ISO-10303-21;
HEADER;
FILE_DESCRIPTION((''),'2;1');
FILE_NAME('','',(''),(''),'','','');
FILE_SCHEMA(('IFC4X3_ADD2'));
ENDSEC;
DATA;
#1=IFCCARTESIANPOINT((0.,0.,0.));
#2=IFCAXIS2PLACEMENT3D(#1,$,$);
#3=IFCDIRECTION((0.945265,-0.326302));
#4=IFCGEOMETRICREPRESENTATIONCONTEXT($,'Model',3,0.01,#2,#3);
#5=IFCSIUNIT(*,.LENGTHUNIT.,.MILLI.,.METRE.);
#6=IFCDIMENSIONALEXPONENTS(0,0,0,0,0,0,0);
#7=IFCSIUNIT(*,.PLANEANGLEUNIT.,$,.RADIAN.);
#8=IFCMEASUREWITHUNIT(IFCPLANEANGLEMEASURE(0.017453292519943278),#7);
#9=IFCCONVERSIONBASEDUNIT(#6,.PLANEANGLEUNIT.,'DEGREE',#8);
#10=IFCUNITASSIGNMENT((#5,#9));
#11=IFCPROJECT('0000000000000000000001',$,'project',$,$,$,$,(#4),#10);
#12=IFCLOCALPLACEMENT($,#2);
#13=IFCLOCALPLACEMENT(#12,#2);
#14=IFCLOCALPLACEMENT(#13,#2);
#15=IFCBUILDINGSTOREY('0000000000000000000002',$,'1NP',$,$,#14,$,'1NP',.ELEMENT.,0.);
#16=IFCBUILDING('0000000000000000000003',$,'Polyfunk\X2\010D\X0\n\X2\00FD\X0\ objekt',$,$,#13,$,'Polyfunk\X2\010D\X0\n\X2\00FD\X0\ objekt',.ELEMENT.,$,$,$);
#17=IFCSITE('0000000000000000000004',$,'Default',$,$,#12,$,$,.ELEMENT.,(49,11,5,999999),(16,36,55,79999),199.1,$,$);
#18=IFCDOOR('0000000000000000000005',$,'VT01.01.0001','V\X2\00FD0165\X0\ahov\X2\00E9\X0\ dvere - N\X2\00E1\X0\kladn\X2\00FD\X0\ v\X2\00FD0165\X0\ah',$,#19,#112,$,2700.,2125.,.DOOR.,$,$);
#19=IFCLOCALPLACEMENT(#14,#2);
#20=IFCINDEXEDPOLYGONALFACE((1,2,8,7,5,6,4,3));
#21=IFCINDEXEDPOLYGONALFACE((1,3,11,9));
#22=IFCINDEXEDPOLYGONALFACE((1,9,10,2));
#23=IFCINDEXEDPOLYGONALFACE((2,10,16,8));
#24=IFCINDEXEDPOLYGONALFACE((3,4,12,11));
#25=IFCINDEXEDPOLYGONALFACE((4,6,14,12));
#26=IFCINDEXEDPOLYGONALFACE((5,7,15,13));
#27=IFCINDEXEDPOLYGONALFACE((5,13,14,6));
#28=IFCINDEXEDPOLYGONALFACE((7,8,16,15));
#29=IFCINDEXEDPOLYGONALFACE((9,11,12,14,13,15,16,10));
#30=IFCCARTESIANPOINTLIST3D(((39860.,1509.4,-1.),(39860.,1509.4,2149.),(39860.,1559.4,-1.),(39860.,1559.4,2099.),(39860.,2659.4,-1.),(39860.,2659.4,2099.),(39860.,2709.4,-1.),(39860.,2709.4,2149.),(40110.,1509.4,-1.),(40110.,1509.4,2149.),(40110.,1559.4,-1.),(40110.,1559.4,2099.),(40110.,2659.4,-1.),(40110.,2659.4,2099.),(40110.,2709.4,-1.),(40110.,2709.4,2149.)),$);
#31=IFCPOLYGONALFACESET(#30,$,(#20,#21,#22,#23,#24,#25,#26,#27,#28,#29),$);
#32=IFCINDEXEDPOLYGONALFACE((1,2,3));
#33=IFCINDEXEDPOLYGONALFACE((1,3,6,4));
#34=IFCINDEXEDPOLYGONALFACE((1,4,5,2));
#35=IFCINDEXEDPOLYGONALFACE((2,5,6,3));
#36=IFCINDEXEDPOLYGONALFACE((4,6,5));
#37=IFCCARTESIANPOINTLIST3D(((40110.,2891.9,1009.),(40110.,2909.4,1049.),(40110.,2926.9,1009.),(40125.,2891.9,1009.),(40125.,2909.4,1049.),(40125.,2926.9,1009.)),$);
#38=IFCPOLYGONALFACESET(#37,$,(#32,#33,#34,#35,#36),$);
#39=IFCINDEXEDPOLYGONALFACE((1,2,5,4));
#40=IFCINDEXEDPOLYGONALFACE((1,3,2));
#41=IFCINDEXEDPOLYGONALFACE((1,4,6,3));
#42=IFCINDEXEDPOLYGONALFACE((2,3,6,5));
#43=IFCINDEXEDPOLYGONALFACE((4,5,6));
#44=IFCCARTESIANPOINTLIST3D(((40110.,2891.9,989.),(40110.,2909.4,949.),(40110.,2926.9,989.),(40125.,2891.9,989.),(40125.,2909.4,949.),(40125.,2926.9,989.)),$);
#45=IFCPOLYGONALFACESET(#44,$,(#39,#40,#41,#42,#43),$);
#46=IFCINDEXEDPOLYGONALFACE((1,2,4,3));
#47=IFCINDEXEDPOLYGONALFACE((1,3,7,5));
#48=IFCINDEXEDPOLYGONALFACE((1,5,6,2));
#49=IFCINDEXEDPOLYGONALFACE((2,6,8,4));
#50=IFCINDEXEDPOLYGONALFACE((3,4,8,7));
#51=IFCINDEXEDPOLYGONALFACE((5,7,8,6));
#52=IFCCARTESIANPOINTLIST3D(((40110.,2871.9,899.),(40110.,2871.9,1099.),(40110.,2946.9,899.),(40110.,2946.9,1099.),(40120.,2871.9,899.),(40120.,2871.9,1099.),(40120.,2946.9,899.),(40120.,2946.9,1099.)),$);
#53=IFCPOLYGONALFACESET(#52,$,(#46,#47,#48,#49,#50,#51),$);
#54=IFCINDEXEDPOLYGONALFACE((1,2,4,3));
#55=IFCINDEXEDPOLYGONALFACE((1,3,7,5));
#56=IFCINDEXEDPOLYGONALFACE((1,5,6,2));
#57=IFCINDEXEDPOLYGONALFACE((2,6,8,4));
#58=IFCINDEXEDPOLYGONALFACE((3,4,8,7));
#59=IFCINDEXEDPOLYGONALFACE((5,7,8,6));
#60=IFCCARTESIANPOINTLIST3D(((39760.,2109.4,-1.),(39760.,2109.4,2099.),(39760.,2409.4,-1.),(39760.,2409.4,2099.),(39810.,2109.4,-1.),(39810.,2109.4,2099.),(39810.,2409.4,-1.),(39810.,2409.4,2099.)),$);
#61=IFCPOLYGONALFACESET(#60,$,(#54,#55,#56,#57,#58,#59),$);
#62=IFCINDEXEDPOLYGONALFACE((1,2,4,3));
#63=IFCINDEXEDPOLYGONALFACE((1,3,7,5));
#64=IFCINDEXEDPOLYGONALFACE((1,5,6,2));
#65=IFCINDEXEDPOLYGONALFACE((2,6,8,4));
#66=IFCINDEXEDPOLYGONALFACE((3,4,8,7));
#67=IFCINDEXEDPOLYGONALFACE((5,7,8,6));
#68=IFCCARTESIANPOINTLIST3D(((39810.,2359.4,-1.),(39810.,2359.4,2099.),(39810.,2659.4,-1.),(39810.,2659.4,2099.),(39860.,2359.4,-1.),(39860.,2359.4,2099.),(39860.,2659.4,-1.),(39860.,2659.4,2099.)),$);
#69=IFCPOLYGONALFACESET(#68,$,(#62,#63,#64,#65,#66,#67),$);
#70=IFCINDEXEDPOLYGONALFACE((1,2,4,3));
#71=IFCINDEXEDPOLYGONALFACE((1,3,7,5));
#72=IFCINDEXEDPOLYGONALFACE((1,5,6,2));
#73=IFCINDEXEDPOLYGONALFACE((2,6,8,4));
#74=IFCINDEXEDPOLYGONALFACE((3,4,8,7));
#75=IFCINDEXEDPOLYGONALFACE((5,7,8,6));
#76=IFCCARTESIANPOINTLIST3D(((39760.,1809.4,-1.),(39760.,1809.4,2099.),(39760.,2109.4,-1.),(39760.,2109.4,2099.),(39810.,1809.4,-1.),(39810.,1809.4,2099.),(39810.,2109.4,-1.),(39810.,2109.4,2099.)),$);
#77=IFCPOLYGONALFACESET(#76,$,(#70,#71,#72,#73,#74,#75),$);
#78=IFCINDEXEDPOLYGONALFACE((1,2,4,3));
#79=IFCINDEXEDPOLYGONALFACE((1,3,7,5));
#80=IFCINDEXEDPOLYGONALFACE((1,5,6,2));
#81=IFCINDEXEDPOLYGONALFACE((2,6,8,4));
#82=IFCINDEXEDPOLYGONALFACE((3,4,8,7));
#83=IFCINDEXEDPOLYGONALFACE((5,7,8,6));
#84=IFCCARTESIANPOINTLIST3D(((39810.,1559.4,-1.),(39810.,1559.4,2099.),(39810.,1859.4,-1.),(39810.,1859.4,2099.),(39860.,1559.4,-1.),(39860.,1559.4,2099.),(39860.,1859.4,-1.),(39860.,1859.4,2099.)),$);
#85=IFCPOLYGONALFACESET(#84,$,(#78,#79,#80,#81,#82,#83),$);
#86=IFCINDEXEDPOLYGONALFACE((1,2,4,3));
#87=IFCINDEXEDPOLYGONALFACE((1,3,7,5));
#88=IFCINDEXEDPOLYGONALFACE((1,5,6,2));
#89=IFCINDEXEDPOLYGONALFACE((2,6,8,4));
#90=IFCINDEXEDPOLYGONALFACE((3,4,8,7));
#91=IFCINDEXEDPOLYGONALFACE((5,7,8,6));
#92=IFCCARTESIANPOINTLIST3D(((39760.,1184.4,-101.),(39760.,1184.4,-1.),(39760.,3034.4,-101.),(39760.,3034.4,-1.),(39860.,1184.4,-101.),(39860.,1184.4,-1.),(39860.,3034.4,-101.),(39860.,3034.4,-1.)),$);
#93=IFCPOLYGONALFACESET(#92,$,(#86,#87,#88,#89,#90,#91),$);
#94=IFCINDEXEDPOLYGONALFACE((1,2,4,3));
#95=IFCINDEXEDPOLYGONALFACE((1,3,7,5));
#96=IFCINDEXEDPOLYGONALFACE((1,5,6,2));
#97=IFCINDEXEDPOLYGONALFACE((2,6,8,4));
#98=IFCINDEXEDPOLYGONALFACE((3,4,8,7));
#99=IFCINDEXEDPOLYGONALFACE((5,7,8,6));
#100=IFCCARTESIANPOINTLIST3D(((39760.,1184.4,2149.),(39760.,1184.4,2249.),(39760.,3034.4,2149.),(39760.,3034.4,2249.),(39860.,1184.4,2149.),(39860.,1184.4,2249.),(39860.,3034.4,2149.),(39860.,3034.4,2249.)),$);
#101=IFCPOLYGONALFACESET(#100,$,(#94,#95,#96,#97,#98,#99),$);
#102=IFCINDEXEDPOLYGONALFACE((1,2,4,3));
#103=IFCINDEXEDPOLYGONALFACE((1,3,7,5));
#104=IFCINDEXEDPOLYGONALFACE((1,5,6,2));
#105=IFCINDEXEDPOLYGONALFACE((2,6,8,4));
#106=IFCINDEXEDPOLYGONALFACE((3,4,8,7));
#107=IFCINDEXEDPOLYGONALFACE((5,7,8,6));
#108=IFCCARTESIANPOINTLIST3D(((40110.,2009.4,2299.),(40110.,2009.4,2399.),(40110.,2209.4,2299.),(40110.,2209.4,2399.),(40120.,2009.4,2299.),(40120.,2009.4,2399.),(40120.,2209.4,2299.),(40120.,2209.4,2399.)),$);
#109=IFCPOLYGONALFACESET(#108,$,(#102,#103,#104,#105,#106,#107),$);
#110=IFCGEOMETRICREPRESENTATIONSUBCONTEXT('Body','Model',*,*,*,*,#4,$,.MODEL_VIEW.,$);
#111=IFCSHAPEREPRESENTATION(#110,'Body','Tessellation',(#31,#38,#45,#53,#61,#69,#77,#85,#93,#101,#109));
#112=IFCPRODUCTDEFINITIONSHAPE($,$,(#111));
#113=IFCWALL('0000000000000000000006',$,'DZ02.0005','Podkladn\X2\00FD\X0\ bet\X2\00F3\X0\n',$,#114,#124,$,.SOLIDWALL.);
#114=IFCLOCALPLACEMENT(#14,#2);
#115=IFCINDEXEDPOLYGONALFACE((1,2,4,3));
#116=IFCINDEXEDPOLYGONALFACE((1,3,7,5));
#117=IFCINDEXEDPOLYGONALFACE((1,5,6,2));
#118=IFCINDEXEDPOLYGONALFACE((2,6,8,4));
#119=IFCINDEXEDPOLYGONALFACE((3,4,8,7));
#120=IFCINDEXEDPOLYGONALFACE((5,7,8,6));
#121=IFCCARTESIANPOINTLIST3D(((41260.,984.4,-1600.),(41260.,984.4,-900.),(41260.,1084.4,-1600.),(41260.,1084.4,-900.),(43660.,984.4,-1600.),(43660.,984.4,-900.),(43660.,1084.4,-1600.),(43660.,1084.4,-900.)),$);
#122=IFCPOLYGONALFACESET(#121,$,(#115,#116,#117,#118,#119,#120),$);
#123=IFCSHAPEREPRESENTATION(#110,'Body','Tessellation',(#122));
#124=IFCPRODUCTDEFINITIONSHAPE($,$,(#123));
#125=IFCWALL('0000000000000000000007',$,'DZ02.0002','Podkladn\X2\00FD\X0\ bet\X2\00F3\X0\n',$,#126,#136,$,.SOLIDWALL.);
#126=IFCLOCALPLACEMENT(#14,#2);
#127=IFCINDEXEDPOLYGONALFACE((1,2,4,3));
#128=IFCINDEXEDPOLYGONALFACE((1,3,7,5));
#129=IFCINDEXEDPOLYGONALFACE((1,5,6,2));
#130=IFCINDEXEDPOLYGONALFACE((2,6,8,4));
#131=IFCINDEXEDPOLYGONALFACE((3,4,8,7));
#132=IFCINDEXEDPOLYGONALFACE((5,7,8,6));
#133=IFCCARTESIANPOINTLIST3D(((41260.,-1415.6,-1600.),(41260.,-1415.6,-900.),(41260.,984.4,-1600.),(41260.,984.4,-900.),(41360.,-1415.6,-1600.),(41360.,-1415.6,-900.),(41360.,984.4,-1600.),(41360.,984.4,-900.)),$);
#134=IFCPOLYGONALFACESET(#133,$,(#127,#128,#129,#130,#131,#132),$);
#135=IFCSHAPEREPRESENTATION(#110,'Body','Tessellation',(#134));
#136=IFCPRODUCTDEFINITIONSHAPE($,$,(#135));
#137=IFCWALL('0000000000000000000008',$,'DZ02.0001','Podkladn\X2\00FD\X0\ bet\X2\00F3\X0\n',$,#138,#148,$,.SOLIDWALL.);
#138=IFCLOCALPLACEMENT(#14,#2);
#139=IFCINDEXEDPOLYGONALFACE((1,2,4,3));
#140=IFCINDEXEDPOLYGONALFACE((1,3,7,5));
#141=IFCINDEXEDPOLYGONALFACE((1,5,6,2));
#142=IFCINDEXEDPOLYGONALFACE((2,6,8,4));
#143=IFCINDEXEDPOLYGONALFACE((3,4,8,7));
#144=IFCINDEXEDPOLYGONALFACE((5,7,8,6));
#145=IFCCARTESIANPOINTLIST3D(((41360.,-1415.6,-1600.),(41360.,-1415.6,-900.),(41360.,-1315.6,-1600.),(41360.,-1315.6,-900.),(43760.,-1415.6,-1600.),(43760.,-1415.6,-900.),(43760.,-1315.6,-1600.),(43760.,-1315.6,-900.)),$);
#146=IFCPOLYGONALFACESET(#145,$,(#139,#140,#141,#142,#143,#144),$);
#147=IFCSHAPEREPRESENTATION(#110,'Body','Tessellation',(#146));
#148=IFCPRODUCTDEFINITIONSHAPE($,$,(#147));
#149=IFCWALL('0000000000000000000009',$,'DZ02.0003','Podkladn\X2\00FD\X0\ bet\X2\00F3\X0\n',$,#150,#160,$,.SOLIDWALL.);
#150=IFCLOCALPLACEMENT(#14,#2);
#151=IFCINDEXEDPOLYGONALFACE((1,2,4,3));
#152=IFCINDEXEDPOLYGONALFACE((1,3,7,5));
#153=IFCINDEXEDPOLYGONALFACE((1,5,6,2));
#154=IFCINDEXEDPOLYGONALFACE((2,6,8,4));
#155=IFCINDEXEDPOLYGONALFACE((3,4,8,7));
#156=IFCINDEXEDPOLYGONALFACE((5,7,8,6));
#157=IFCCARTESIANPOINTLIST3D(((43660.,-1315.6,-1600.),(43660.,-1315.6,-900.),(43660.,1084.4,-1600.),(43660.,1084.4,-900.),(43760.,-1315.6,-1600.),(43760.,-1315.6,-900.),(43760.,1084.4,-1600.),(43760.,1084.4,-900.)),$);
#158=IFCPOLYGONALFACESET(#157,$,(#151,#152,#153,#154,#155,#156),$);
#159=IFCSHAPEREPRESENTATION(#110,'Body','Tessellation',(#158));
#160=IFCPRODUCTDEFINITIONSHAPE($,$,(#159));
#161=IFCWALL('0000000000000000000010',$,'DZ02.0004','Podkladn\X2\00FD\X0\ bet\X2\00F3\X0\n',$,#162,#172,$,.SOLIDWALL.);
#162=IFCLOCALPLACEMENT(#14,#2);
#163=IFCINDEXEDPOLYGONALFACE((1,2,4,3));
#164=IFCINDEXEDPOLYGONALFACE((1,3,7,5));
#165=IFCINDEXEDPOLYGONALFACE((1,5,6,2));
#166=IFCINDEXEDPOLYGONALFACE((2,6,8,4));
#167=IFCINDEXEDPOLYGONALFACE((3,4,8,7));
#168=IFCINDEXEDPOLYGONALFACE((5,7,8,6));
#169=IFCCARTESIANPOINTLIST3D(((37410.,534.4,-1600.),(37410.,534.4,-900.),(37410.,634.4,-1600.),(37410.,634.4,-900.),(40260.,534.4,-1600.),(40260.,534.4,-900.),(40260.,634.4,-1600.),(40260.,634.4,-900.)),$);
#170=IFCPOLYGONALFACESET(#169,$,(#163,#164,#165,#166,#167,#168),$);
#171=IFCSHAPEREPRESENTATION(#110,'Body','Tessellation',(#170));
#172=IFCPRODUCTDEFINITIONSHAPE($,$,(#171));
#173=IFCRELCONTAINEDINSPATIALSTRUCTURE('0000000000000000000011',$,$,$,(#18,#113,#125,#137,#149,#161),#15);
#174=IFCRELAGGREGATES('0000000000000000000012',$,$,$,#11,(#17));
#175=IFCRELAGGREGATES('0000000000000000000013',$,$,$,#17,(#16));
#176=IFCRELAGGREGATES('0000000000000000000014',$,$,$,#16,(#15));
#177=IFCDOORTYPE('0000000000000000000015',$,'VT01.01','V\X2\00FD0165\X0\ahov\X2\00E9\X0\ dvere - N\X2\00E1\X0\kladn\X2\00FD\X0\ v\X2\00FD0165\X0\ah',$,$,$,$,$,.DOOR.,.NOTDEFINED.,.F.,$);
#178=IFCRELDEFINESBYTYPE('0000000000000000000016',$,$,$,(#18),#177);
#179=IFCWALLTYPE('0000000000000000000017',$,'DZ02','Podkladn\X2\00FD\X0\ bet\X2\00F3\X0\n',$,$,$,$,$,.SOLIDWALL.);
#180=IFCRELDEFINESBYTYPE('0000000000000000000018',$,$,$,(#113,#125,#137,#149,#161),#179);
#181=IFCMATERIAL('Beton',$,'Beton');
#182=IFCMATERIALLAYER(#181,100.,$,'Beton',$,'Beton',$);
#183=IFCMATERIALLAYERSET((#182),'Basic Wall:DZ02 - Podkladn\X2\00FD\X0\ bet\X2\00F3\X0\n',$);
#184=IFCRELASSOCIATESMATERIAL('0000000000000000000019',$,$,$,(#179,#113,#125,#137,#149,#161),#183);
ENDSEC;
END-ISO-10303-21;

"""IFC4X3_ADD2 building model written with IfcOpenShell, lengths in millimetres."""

from ifc_helpers import new_model, entity, si_unit, converted_unit, direction, frame, frame_2d, origin, origin_2d_with_axis, place, context, subcontext, project, spatial, polyline, rectangle, outline, extrude, source, transform, mapped, material, layer, layer_set, type_object, type_shapes, element, save


model = new_model("IFC4X3_ADD2")

# Units and contexts
model_context = context("Model", 3, precision=0.01, world=origin(), true_north=direction((0.945265, -0.326302)))
body_context = subcontext(model_context, "Body", "Model", "MODEL_VIEW")
ifc_project = project(units=[si_unit("LENGTHUNIT", "METRE", prefix="MILLI"), converted_unit("PLANEANGLEUNIT", "DEGREE", entity("IfcPlaneAngleMeasure", 0.017453292519943278), si_unit("PLANEANGLEUNIT", "RADIAN"), dimensions=[0, 0, 0, 0, 0, 0, 0])], contexts=[model_context])

# Site, building, storey
site_placement = place(None, origin())
site = spatial("IfcSite", under=ifc_project, at=site_placement, Name="Default", CompositionType="ELEMENT", RefLatitude=(49, 11, 5, 999999), RefLongitude=(16, 36, 55, 79999), RefElevation=199.1)
building_placement = place(site_placement, origin())
building = spatial("IfcBuilding", under=site, at=building_placement, Name="Polyfunkčný objekt", LongName="Polyfunkčný objekt", CompositionType="ELEMENT")
storey_placement = place(building_placement, origin())
storey = spatial("IfcBuildingStorey", under=building, at=storey_placement, Name="1NP", LongName="1NP", CompositionType="ELEMENT", Elevation=0.0)

# Door
door_type_1 = type_object("IfcDoorType", Name="VT01.01", Description="Výťahové dvere - Nákladný výťah", OperationType="NOTDEFINED", ParameterTakesPrecedence=False, PredefinedType="DOOR")
shared_shape_1 = source(origin(), body_context, "Body", "SweptSolid", [
    extrude(outline(polyline([(-1087.5, -600.0), (1062.5, -600.0), (1062.5, -550.0), (-1037.5, -550.0), (-1037.5, 550.0), (1062.5, 550.0), (1062.5, 600.0), (-1087.5, 600.0), (-1087.5, -600.0)])), frame((600.0, 0.0, 1062.5), z_axis=(0.0, 1.0, 0.0), x_axis=(0.0, 0.0, -1.0)), (0.0, 0.0, 1.0), 250.0),
    extrude(outline(polyline([(-24.4, -10.7), (19.2, -10.7), (5.2, 21.4), (-24.4, -10.7)])), frame((1400.0, -15.0, 1023.3), z_axis=(0.0, 1.0, 0.0), x_axis=(0.400819, 0.0, -0.916157)), (0.0, 0.0, 1.0), 15.0),
    extrude(outline(polyline([(-24.4, -10.7), (19.2, -10.7), (5.2, 21.4), (-24.4, -10.7)])), frame((1400.0, -15.0, 976.7), z_axis=(0.0, 1.0, 0.0), x_axis=(-0.400819, 0.0, 0.916157)), (0.0, 0.0, 1.0), 15.0),
    extrude(rectangle(XDim=10.0, YDim=75.0, at=frame_2d((0.0, 0.0), x_axis=(1.0, 0.0))), frame((1400.0, -5.0, 900.0), z_axis=(0.0, 0.0, 1.0), x_axis=(0.0, 1.0, 0.0)), (0.0, 0.0, 1.0), 200.0),
    extrude(rectangle(XDim=50.0, YDim=300.0, at=origin_2d_with_axis()), frame((750.0, 325.0, 0.0), z_axis=(0.0, 0.0, 1.0), x_axis=(0.0, -1.0, 0.0)), (0.0, 0.0, 1.0), 2100.0),
    extrude(rectangle(XDim=50.0, YDim=300.0, at=frame_2d((0.0, 0.0), x_axis=(1.0, 0.0))), frame((1000.0, 275.0, 0.0), z_axis=(0.0, 0.0, 1.0), x_axis=(0.0, -1.0, 0.0)), (0.0, 0.0, 1.0), 2100.0),
    extrude(rectangle(XDim=300.0, YDim=50.0, at=frame_2d((0.0, 0.0), x_axis=(1.0, 0.0))), frame((450.0, 325.0, 0.0), z_axis=(0.0, 0.0, 1.0), x_axis=(-1.0, 0.0, 0.0)), (0.0, 0.0, 1.0), 2100.0),
    extrude(rectangle(XDim=300.0, YDim=50.0, at=frame_2d((0.0, 0.0), x_axis=(1.0, 0.0))), frame((200.0, 275.0, 0.0), z_axis=(0.0, 0.0, 1.0), x_axis=(-1.0, 0.0, 0.0)), (0.0, 0.0, 1.0), 2100.0),
    extrude(rectangle(XDim=1850.0, YDim=100.0, at=frame_2d((0.0, 0.0), x_axis=(1.0, 0.0))), frame((600.0, 300.0, -100.0), z_axis=(0.0, 0.0, 1.0), x_axis=(-1.0, 0.0, 0.0)), (0.0, 0.0, 1.0), 100.0),
    extrude(rectangle(XDim=1850.0, YDim=100.0, at=frame_2d((0.0, 0.0), x_axis=(1.0, 0.0))), frame((600.0, 300.0, 2150.0), z_axis=(0.0, 0.0, 1.0), x_axis=(-1.0, 0.0, 0.0)), (0.0, 0.0, 1.0), 100.0),
    extrude(rectangle(XDim=10.0, YDim=200.0, at=frame_2d((0.0, 0.0), x_axis=(1.0, 0.0))), frame((600.0, -5.0, 2300.0), z_axis=(0.0, 0.0, 1.0), x_axis=(0.0, 1.0, 0.0)), (0.0, 0.0, 1.0), 100.0),
])
type_shapes(door_type_1, [shared_shape_1])
door_1_placement = place(storey_placement, frame((40110.0, 1509.4, -1.0), z_axis=(0.0, 0.0, 1.0), x_axis=(0.0, 1.0, 0.0)))
element("IfcDoor", 1, at=door_1_placement, inside=storey, type_object=door_type_1, Name="VT01.01.0001", Description="Výťahové dvere - Nákladný výťah", OverallHeight=2700.0, OverallWidth=2125.0, PredefinedType="DOOR", context=body_context, shape_type="MappedRepresentation", body=[
    mapped(shared_shape_1, transform((0.0, 0.0, 0.0), scale=1.0)),
])

# Walls
ifc_material_1 = material(Name="Beton", Category="Beton")
ifc_layer_1 = layer(ifc_material_1, 100.0, Name="Beton", Category="Beton")
ifc_layer_set_1 = layer_set([ifc_layer_1], Name="Basic Wall:DZ02 - Podkladný betón")
wall_type_1 = type_object("IfcWallType", Name="DZ02", Description="Podkladný betón", PredefinedType="SOLIDWALL", material=ifc_layer_set_1)
wall_1_placement = place(storey_placement, frame((41260.0, 1034.4, -1600.0)))
element("IfcWall", 2, at=wall_1_placement, inside=storey, type_object=wall_type_1, material=ifc_layer_set_1, Name="DZ02.0005", Description="Podkladný betón", PredefinedType="SOLIDWALL", context=body_context, shape_type="SweptSolid", body=[
    extrude(rectangle(XDim=2400.0, YDim=100.0, at=frame_2d((1200.0, 0.0), x_axis=(-1.0, 0.0))), origin(), (0.0, 0.0, 1.0), 700.0),
])
wall_2_placement = place(storey_placement, frame((41310.0, -1415.6, -1600.0), z_axis=(0.0, 0.0, 1.0), x_axis=(0.0, 1.0, 0.0)))
element("IfcWall", 3, at=wall_2_placement, inside=storey, type_object=wall_type_1, material=ifc_layer_set_1, Name="DZ02.0002", Description="Podkladný betón", PredefinedType="SOLIDWALL", context=body_context, shape_type="SweptSolid", body=[
    extrude(rectangle(XDim=2400.0, YDim=100.0, at=frame_2d((1200.0, 0.0), x_axis=(-1.0, 0.0))), origin(), (0.0, 0.0, 1.0), 700.0),
])
wall_3_placement = place(storey_placement, frame((43760.0, -1365.6, -1600.0), z_axis=(0.0, 0.0, 1.0), x_axis=(-1.0, 0.0, 0.0)))
element("IfcWall", 4, at=wall_3_placement, inside=storey, type_object=wall_type_1, material=ifc_layer_set_1, Name="DZ02.0001", Description="Podkladný betón", PredefinedType="SOLIDWALL", context=body_context, shape_type="SweptSolid", body=[
    extrude(rectangle(XDim=2400.0, YDim=100.0, at=frame_2d((1200.0, 0.0), x_axis=(-1.0, 0.0))), origin(), (0.0, 0.0, 1.0), 700.0),
])
wall_4_placement = place(storey_placement, frame((43710.0, 1084.4, -1600.0), z_axis=(0.0, 0.0, 1.0), x_axis=(0.0, -1.0, 0.0)))
element("IfcWall", 5, at=wall_4_placement, inside=storey, type_object=wall_type_1, material=ifc_layer_set_1, Name="DZ02.0003", Description="Podkladný betón", PredefinedType="SOLIDWALL", context=body_context, shape_type="SweptSolid", body=[
    extrude(rectangle(XDim=2400.0, YDim=100.0, at=frame_2d((1200.0, 0.0), x_axis=(-1.0, 0.0))), origin(), (0.0, 0.0, 1.0), 700.0),
])
wall_5_placement = place(storey_placement, frame((40260.0, 584.4, -1600.0), z_axis=(0.0, 0.0, 1.0), x_axis=(-1.0, 0.0, 0.0)))
element("IfcWall", 6, at=wall_5_placement, inside=storey, type_object=wall_type_1, material=ifc_layer_set_1, Name="DZ02.0004", Description="Podkladný betón", PredefinedType="SOLIDWALL", context=body_context, shape_type="SweptSolid", body=[
    extrude(rectangle(XDim=2850.0, YDim=100.0, at=frame_2d((1425.0, 0.0), x_axis=(-1.0, 0.0))), origin(), (0.0, 0.0, 1.0), 700.0),
])

save(model, "model.ifc")
